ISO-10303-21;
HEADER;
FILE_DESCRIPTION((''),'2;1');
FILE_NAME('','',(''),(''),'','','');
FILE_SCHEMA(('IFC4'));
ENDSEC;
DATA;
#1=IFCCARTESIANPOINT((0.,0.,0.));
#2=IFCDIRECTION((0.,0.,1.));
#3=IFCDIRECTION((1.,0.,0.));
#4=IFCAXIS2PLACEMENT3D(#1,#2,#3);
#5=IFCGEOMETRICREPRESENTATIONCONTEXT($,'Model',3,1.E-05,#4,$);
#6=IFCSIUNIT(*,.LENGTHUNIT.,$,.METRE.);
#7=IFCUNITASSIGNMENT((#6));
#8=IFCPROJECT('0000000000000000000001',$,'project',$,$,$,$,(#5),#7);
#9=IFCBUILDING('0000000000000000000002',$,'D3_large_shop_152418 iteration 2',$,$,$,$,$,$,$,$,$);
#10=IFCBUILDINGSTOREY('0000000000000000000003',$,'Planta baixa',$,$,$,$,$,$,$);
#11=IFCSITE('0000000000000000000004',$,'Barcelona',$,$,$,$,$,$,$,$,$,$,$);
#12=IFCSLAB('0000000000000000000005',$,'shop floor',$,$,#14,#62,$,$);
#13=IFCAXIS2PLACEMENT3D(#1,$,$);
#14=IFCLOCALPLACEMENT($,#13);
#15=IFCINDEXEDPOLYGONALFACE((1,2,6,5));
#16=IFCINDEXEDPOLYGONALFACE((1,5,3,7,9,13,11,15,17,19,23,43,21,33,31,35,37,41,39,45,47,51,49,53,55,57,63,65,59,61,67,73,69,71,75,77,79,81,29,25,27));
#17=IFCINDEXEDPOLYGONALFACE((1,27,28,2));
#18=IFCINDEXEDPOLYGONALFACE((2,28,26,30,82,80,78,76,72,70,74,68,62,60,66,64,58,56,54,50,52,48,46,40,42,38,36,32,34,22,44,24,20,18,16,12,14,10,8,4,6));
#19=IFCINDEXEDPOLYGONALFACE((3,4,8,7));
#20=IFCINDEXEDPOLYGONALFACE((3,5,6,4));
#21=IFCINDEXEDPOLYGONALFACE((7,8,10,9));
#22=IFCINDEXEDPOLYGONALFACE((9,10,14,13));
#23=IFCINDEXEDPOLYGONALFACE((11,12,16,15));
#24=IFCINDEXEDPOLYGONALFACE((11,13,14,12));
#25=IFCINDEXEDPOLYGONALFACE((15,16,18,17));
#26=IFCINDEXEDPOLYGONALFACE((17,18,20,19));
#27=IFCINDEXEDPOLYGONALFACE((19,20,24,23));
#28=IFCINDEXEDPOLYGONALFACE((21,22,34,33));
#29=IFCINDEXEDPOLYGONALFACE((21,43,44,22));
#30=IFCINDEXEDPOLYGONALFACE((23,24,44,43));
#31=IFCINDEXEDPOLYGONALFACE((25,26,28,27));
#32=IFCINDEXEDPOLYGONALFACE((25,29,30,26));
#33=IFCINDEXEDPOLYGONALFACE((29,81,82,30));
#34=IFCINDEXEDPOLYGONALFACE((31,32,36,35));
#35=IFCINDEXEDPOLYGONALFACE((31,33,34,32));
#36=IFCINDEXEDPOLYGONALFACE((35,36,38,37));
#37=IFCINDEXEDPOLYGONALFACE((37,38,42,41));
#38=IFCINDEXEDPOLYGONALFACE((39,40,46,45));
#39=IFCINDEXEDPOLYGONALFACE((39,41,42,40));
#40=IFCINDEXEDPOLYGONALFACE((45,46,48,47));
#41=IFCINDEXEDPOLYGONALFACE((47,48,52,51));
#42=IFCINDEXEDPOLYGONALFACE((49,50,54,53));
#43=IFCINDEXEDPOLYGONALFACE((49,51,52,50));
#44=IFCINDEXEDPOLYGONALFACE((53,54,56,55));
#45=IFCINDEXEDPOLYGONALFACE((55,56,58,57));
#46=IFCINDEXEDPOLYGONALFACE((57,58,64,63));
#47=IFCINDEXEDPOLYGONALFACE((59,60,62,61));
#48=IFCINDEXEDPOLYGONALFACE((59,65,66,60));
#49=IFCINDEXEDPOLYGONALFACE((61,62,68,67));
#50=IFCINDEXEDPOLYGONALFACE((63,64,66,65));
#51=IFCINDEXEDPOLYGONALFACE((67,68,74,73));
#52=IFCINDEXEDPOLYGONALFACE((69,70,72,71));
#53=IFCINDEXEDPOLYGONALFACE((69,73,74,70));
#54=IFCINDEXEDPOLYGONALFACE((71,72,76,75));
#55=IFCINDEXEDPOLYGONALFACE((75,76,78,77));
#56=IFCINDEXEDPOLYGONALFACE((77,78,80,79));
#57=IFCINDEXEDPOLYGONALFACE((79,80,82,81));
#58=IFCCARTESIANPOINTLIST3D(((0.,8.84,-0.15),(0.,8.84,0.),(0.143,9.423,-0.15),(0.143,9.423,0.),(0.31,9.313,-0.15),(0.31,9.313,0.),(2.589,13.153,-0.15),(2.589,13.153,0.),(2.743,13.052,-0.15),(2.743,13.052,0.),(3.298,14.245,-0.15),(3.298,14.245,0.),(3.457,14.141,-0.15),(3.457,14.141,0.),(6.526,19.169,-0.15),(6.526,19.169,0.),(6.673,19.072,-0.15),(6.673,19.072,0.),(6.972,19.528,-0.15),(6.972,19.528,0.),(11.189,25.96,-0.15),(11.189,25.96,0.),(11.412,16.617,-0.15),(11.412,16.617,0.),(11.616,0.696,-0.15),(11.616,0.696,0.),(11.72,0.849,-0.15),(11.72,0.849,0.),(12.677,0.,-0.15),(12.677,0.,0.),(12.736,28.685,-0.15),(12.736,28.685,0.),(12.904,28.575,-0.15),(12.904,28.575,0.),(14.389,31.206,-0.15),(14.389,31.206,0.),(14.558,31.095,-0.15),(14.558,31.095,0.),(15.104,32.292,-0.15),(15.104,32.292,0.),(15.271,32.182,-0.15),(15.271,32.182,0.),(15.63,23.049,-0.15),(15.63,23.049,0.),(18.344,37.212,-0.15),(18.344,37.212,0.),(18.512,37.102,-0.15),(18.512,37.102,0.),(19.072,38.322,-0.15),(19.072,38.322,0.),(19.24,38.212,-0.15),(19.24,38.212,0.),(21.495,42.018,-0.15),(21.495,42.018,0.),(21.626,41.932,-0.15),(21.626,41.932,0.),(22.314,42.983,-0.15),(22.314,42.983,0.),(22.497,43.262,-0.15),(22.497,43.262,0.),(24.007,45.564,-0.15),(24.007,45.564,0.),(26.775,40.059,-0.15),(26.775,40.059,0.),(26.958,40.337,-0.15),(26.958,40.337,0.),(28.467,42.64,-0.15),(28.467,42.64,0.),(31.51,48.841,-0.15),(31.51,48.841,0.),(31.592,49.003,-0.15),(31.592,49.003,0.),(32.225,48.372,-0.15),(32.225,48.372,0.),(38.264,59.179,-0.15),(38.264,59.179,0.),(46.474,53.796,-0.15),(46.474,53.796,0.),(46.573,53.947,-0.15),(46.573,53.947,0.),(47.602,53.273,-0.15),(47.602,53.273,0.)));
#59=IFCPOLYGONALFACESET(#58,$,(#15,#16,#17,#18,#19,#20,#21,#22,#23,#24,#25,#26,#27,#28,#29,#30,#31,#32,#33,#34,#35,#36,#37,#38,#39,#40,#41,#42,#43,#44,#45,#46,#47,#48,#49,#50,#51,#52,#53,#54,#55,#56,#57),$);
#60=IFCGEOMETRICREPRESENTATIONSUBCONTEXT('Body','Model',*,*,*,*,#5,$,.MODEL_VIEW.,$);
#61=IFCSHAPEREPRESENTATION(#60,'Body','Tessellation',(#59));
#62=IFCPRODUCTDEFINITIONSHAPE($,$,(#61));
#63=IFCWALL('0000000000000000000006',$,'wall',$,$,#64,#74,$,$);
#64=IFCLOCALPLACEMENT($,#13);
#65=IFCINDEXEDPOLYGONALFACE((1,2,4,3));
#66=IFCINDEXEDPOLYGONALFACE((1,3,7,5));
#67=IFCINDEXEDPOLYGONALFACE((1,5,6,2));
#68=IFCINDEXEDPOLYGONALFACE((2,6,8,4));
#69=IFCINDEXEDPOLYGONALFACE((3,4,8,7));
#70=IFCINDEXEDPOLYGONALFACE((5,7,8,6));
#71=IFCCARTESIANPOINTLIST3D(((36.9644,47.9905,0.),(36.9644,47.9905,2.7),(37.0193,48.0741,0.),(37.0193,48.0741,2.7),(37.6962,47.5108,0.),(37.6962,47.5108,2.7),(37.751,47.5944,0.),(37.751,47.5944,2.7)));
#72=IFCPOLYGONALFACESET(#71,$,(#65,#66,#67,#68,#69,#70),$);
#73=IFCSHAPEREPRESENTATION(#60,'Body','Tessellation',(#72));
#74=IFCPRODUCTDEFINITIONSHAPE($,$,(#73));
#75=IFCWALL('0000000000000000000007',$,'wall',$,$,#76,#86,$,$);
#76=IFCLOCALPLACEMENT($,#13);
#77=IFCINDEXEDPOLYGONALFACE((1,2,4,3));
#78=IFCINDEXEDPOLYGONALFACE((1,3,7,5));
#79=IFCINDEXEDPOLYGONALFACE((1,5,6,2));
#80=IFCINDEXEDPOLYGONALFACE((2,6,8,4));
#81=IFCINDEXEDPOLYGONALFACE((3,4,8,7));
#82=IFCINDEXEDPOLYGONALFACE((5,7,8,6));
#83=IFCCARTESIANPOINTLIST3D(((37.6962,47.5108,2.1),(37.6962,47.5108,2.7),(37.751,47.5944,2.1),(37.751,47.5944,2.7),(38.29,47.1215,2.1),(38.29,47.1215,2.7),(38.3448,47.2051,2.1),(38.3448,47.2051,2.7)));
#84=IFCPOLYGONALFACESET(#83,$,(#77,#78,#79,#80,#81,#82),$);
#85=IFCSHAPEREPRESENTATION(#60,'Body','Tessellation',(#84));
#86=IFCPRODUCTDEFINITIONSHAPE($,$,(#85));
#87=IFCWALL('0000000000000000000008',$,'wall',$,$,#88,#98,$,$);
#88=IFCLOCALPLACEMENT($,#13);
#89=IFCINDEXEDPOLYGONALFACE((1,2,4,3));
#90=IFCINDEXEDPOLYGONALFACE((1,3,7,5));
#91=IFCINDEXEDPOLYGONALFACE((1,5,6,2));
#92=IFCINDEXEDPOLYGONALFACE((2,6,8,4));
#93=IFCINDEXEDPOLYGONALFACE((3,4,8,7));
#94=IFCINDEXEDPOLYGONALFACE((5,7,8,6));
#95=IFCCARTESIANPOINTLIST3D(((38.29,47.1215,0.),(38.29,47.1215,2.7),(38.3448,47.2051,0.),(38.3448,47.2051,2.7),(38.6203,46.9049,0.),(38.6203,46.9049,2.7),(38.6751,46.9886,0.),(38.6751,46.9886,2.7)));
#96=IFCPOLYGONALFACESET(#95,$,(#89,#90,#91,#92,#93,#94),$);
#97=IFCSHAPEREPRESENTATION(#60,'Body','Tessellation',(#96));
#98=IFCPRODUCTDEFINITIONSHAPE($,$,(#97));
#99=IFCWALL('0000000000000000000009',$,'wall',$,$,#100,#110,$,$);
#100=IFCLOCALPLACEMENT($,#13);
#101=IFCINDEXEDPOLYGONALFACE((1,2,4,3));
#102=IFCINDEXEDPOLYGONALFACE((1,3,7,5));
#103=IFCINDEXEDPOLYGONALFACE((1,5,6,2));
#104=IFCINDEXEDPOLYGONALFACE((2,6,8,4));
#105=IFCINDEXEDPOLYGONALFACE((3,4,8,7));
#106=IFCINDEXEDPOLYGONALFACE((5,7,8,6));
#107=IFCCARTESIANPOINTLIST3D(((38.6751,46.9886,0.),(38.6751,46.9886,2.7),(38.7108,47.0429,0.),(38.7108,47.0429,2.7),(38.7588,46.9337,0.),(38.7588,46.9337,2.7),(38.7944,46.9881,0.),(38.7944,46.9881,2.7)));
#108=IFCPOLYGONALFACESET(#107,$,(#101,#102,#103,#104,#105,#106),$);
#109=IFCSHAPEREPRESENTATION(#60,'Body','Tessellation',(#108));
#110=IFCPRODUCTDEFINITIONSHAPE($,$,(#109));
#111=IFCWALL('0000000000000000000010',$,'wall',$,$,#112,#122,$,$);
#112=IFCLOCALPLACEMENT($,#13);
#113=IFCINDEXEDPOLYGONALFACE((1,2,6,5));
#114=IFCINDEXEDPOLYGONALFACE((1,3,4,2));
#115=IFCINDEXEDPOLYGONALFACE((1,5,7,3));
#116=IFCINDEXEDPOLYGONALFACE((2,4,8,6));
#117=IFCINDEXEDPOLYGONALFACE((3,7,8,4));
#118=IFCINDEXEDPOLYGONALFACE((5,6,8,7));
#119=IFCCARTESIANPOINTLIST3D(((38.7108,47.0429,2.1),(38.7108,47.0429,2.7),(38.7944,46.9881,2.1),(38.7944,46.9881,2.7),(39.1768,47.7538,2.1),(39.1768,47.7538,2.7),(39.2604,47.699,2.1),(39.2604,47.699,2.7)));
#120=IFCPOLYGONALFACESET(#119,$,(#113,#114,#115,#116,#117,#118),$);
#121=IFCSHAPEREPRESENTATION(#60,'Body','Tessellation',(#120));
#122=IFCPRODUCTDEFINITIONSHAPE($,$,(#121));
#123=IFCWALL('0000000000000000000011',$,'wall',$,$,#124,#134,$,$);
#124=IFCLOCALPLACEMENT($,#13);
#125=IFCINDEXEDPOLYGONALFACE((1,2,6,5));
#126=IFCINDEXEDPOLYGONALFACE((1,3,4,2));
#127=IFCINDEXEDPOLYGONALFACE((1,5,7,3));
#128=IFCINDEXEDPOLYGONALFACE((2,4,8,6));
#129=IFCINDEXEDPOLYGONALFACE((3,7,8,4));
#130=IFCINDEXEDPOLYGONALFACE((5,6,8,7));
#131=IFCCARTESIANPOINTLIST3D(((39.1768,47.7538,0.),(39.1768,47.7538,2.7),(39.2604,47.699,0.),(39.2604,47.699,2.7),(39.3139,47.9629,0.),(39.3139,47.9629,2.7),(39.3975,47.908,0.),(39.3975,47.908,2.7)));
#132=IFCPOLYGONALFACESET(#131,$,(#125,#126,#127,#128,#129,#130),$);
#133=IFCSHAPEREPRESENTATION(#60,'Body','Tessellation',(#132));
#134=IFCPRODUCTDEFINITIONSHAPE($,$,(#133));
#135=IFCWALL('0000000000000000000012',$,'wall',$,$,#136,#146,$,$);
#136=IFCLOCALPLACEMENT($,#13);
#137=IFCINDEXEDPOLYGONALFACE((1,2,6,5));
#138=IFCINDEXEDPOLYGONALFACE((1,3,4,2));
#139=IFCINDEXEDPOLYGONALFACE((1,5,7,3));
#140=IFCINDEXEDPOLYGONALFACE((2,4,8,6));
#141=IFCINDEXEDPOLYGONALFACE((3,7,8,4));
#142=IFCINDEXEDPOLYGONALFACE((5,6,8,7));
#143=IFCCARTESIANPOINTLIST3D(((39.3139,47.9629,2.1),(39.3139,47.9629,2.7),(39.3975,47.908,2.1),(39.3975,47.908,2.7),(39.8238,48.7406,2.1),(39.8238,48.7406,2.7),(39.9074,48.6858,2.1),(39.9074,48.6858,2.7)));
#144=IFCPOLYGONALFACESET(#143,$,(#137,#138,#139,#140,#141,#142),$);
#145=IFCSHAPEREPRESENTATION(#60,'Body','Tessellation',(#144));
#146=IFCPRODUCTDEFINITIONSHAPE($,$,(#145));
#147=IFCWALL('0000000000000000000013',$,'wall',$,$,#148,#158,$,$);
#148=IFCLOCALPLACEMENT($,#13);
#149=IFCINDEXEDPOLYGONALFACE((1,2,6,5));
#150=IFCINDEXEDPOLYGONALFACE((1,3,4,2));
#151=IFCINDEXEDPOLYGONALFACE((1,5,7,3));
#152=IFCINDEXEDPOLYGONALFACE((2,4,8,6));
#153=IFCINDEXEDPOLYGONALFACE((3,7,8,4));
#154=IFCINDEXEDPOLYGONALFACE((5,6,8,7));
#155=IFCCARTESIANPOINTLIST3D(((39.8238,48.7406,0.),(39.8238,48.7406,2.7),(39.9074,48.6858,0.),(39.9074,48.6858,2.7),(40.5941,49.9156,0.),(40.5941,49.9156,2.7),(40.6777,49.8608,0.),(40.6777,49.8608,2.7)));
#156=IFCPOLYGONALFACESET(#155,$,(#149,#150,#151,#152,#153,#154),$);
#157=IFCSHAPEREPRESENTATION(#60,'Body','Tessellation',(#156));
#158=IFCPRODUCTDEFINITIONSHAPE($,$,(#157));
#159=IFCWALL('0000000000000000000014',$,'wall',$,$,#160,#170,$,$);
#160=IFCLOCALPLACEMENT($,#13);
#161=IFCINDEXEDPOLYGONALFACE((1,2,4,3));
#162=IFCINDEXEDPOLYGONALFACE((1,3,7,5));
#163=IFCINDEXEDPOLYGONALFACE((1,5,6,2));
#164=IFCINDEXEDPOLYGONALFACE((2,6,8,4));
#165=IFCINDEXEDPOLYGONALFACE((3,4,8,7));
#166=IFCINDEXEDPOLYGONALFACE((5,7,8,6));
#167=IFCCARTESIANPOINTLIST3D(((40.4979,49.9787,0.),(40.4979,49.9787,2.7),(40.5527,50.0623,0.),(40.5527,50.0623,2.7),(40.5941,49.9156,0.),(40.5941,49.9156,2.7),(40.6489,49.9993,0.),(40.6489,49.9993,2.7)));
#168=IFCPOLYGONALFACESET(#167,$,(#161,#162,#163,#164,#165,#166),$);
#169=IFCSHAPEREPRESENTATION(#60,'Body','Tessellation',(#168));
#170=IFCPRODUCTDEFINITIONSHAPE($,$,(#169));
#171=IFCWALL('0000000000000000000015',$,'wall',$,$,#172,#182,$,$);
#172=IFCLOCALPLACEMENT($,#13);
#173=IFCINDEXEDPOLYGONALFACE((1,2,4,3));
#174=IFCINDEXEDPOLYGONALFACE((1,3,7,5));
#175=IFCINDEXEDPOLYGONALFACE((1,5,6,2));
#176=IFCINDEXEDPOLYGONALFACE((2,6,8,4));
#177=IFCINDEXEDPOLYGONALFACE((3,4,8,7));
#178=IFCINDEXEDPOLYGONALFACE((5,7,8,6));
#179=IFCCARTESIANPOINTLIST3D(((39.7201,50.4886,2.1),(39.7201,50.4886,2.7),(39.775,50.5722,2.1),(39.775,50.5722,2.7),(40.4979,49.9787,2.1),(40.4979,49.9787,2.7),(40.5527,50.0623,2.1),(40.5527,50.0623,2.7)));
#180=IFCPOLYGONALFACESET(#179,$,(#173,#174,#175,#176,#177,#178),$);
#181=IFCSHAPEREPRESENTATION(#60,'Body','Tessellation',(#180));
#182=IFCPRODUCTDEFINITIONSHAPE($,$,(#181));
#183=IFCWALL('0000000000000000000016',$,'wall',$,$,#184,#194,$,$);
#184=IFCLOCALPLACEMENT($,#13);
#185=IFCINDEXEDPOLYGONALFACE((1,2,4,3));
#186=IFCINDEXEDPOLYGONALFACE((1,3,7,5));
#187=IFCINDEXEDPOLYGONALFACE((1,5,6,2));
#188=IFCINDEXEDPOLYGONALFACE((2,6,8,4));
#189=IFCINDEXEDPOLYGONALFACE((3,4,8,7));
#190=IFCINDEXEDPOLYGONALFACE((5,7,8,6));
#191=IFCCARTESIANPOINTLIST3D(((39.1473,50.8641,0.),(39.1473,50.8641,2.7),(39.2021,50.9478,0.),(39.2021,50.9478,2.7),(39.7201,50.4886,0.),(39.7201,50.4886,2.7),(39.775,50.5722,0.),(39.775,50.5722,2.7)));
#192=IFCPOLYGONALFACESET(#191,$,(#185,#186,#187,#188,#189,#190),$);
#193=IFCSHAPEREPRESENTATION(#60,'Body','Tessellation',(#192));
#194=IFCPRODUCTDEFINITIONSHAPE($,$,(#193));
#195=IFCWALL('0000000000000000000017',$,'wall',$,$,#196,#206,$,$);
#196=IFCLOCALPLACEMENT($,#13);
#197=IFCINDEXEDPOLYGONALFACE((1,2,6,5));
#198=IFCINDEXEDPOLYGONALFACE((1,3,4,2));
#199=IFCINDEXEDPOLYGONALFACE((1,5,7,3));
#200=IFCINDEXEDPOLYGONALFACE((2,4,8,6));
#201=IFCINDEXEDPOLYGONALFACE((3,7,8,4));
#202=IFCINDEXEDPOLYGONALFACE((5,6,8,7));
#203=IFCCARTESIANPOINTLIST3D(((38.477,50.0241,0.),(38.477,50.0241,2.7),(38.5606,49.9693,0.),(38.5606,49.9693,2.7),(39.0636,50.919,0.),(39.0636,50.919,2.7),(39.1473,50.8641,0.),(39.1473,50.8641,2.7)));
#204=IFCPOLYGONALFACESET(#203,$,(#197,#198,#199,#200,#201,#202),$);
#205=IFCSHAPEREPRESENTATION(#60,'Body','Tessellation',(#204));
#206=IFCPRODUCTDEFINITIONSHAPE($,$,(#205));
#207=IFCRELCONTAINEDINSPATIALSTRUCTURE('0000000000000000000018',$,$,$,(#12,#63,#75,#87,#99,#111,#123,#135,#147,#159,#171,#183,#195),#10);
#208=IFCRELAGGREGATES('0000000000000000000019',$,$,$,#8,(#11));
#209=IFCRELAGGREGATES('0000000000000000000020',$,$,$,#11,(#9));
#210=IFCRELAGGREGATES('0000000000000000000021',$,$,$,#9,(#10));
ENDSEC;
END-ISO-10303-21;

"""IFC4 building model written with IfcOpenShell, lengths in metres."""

from ifc_helpers import new_model, si_unit, frame, origin, origin_with_axes, place, context, subcontext, project, spatial, polyline, outline, extrude, element, save


model = new_model("IFC4")

# Units and contexts
model_context = context("Model", 3, precision=1e-05, world=origin_with_axes())
body_context = subcontext(model_context, "Body", "Model", "MODEL_VIEW")
ifc_project = project(units=[si_unit("LENGTHUNIT", "METRE")], contexts=[model_context])

# Site, building, storey
site = spatial("IfcSite", under=ifc_project, Name="Barcelona")
building = spatial("IfcBuilding", under=site, Name="D3_large_shop_152418 iteration 2")
storey = spatial("IfcBuildingStorey", under=building, Name="Planta baixa")

# Slab
slab_placement = place(None, origin_with_axes())
element("IfcSlab", 1, at=slab_placement, inside=storey, Name="shop floor", context=body_context, shape_type="SweptSolid", body=[
    extrude(outline(polyline([(15.63, 23.049), (11.189, 25.96), (12.904, 28.575), (12.736, 28.685), (14.389, 31.206), (14.558, 31.095), (15.271, 32.182), (15.104, 32.292), (18.344, 37.212), (18.512, 37.102), (19.24, 38.212), (19.072, 38.322), (21.495, 42.018), (21.626, 41.932), (22.314, 42.983), (26.775, 40.059), (26.958, 40.337), (22.497, 43.262), (24.007, 45.564), (28.467, 42.64), (32.225, 48.372), (31.51, 48.841), (31.592, 49.003), (38.264, 59.179), (46.474, 53.796), (46.573, 53.947), (47.602, 53.273), (12.677, 0.0), (11.616, 0.696), (11.72, 0.849), (0.0, 8.84), (0.31, 9.313), (0.143, 9.423), (2.589, 13.153), (2.743, 13.052), (3.457, 14.141), (3.298, 14.245), (6.526, 19.169), (6.673, 19.072), (6.972, 19.528), (11.412, 16.617), (15.63, 23.049)])), frame((0.0, 0.0, -0.15)), (0.0, 0.0, 1.0), 0.15),
])

# Walls
wall_1_placement = place(None, origin_with_axes())
element("IfcWall", 2, at=wall_1_placement, inside=storey, Name="wall", context=body_context, shape_type="SweptSolid", body=[
    extrude(outline(polyline([(37.0193, 48.0741), (37.751, 47.5944), (37.6962, 47.5108), (36.9644, 47.9905), (37.0193, 48.0741)])), origin(), (0.0, 0.0, 1.0), 2.7),
])
wall_2_placement = place(None, origin_with_axes())
element("IfcWall", 3, at=wall_2_placement, inside=storey, Name="wall", context=body_context, shape_type="SweptSolid", body=[
    extrude(outline(polyline([(37.751, 47.5944), (38.3448, 47.2051), (38.29, 47.1215), (37.6962, 47.5108), (37.751, 47.5944)])), frame((0.0, 0.0, 2.1)), (0.0, 0.0, 1.0), 0.6),
])
wall_3_placement = place(None, origin_with_axes())
element("IfcWall", 4, at=wall_3_placement, inside=storey, Name="wall", context=body_context, shape_type="SweptSolid", body=[
    extrude(outline(polyline([(38.3448, 47.2051), (38.6751, 46.9886), (38.6203, 46.9049), (38.29, 47.1215), (38.3448, 47.2051)])), origin(), (0.0, 0.0, 1.0), 2.7),
])
wall_4_placement = place(None, origin_with_axes())
element("IfcWall", 5, at=wall_4_placement, inside=storey, Name="wall", context=body_context, shape_type="SweptSolid", body=[
    extrude(outline(polyline([(38.6751, 46.9886), (38.7108, 47.0429), (38.7944, 46.9881), (38.7588, 46.9337), (38.6751, 46.9886)])), origin(), (0.0, 0.0, 1.0), 2.7),
])
wall_5_placement = place(None, origin_with_axes())
element("IfcWall", 6, at=wall_5_placement, inside=storey, Name="wall", context=body_context, shape_type="SweptSolid", body=[
    extrude(outline(polyline([(38.7108, 47.0429), (39.1768, 47.7538), (39.2604, 47.699), (38.7944, 46.9881), (38.7108, 47.0429)])), frame((0.0, 0.0, 2.1)), (0.0, 0.0, 1.0), 0.6),
])
wall_6_placement = place(None, origin_with_axes())
element("IfcWall", 7, at=wall_6_placement, inside=storey, Name="wall", context=body_context, shape_type="SweptSolid", body=[
    extrude(outline(polyline([(39.1768, 47.7538), (39.3139, 47.9629), (39.3975, 47.908), (39.2604, 47.699), (39.1768, 47.7538)])), origin(), (0.0, 0.0, 1.0), 2.7),
])
wall_7_placement = place(None, origin_with_axes())
element("IfcWall", 8, at=wall_7_placement, inside=storey, Name="wall", context=body_context, shape_type="SweptSolid", body=[
    extrude(outline(polyline([(39.3139, 47.9629), (39.8238, 48.7406), (39.9074, 48.6858), (39.3975, 47.908), (39.3139, 47.9629)])), frame((0.0, 0.0, 2.1)), (0.0, 0.0, 1.0), 0.6),
])
wall_8_placement = place(None, origin_with_axes())
element("IfcWall", 9, at=wall_8_placement, inside=storey, Name="wall", context=body_context, shape_type="SweptSolid", body=[
    extrude(outline(polyline([(39.8238, 48.7406), (40.5941, 49.9156), (40.6777, 49.8608), (39.9074, 48.6858), (39.8238, 48.7406)])), origin(), (0.0, 0.0, 1.0), 2.7),
])
wall_9_placement = place(None, origin_with_axes())
element("IfcWall", 10, at=wall_9_placement, inside=storey, Name="wall", context=body_context, shape_type="SweptSolid", body=[
    extrude(outline(polyline([(40.5941, 49.9156), (40.4979, 49.9787), (40.5527, 50.0623), (40.6489, 49.9993), (40.5941, 49.9156)])), origin(), (0.0, 0.0, 1.0), 2.7),
])
wall_10_placement = place(None, origin_with_axes())
element("IfcWall", 11, at=wall_10_placement, inside=storey, Name="wall", context=body_context, shape_type="SweptSolid", body=[
    extrude(outline(polyline([(40.4979, 49.9787), (39.7201, 50.4886), (39.775, 50.5722), (40.5527, 50.0623), (40.4979, 49.9787)])), frame((0.0, 0.0, 2.1)), (0.0, 0.0, 1.0), 0.6),
])
wall_11_placement = place(None, origin_with_axes())
element("IfcWall", 12, at=wall_11_placement, inside=storey, Name="wall", context=body_context, shape_type="SweptSolid", body=[
    extrude(outline(polyline([(39.7201, 50.4886), (39.1473, 50.8641), (39.2021, 50.9478), (39.775, 50.5722), (39.7201, 50.4886)])), origin(), (0.0, 0.0, 1.0), 2.7),
])
wall_12_placement = place(None, origin_with_axes())
element("IfcWall", 13, at=wall_12_placement, inside=storey, Name="wall", context=body_context, shape_type="SweptSolid", body=[
    extrude(outline(polyline([(39.1473, 50.8641), (38.5606, 49.9693), (38.477, 50.0241), (39.0636, 50.919), (39.1473, 50.8641)])), origin(), (0.0, 0.0, 1.0), 2.7),
])

save(model, "model.ifc")
